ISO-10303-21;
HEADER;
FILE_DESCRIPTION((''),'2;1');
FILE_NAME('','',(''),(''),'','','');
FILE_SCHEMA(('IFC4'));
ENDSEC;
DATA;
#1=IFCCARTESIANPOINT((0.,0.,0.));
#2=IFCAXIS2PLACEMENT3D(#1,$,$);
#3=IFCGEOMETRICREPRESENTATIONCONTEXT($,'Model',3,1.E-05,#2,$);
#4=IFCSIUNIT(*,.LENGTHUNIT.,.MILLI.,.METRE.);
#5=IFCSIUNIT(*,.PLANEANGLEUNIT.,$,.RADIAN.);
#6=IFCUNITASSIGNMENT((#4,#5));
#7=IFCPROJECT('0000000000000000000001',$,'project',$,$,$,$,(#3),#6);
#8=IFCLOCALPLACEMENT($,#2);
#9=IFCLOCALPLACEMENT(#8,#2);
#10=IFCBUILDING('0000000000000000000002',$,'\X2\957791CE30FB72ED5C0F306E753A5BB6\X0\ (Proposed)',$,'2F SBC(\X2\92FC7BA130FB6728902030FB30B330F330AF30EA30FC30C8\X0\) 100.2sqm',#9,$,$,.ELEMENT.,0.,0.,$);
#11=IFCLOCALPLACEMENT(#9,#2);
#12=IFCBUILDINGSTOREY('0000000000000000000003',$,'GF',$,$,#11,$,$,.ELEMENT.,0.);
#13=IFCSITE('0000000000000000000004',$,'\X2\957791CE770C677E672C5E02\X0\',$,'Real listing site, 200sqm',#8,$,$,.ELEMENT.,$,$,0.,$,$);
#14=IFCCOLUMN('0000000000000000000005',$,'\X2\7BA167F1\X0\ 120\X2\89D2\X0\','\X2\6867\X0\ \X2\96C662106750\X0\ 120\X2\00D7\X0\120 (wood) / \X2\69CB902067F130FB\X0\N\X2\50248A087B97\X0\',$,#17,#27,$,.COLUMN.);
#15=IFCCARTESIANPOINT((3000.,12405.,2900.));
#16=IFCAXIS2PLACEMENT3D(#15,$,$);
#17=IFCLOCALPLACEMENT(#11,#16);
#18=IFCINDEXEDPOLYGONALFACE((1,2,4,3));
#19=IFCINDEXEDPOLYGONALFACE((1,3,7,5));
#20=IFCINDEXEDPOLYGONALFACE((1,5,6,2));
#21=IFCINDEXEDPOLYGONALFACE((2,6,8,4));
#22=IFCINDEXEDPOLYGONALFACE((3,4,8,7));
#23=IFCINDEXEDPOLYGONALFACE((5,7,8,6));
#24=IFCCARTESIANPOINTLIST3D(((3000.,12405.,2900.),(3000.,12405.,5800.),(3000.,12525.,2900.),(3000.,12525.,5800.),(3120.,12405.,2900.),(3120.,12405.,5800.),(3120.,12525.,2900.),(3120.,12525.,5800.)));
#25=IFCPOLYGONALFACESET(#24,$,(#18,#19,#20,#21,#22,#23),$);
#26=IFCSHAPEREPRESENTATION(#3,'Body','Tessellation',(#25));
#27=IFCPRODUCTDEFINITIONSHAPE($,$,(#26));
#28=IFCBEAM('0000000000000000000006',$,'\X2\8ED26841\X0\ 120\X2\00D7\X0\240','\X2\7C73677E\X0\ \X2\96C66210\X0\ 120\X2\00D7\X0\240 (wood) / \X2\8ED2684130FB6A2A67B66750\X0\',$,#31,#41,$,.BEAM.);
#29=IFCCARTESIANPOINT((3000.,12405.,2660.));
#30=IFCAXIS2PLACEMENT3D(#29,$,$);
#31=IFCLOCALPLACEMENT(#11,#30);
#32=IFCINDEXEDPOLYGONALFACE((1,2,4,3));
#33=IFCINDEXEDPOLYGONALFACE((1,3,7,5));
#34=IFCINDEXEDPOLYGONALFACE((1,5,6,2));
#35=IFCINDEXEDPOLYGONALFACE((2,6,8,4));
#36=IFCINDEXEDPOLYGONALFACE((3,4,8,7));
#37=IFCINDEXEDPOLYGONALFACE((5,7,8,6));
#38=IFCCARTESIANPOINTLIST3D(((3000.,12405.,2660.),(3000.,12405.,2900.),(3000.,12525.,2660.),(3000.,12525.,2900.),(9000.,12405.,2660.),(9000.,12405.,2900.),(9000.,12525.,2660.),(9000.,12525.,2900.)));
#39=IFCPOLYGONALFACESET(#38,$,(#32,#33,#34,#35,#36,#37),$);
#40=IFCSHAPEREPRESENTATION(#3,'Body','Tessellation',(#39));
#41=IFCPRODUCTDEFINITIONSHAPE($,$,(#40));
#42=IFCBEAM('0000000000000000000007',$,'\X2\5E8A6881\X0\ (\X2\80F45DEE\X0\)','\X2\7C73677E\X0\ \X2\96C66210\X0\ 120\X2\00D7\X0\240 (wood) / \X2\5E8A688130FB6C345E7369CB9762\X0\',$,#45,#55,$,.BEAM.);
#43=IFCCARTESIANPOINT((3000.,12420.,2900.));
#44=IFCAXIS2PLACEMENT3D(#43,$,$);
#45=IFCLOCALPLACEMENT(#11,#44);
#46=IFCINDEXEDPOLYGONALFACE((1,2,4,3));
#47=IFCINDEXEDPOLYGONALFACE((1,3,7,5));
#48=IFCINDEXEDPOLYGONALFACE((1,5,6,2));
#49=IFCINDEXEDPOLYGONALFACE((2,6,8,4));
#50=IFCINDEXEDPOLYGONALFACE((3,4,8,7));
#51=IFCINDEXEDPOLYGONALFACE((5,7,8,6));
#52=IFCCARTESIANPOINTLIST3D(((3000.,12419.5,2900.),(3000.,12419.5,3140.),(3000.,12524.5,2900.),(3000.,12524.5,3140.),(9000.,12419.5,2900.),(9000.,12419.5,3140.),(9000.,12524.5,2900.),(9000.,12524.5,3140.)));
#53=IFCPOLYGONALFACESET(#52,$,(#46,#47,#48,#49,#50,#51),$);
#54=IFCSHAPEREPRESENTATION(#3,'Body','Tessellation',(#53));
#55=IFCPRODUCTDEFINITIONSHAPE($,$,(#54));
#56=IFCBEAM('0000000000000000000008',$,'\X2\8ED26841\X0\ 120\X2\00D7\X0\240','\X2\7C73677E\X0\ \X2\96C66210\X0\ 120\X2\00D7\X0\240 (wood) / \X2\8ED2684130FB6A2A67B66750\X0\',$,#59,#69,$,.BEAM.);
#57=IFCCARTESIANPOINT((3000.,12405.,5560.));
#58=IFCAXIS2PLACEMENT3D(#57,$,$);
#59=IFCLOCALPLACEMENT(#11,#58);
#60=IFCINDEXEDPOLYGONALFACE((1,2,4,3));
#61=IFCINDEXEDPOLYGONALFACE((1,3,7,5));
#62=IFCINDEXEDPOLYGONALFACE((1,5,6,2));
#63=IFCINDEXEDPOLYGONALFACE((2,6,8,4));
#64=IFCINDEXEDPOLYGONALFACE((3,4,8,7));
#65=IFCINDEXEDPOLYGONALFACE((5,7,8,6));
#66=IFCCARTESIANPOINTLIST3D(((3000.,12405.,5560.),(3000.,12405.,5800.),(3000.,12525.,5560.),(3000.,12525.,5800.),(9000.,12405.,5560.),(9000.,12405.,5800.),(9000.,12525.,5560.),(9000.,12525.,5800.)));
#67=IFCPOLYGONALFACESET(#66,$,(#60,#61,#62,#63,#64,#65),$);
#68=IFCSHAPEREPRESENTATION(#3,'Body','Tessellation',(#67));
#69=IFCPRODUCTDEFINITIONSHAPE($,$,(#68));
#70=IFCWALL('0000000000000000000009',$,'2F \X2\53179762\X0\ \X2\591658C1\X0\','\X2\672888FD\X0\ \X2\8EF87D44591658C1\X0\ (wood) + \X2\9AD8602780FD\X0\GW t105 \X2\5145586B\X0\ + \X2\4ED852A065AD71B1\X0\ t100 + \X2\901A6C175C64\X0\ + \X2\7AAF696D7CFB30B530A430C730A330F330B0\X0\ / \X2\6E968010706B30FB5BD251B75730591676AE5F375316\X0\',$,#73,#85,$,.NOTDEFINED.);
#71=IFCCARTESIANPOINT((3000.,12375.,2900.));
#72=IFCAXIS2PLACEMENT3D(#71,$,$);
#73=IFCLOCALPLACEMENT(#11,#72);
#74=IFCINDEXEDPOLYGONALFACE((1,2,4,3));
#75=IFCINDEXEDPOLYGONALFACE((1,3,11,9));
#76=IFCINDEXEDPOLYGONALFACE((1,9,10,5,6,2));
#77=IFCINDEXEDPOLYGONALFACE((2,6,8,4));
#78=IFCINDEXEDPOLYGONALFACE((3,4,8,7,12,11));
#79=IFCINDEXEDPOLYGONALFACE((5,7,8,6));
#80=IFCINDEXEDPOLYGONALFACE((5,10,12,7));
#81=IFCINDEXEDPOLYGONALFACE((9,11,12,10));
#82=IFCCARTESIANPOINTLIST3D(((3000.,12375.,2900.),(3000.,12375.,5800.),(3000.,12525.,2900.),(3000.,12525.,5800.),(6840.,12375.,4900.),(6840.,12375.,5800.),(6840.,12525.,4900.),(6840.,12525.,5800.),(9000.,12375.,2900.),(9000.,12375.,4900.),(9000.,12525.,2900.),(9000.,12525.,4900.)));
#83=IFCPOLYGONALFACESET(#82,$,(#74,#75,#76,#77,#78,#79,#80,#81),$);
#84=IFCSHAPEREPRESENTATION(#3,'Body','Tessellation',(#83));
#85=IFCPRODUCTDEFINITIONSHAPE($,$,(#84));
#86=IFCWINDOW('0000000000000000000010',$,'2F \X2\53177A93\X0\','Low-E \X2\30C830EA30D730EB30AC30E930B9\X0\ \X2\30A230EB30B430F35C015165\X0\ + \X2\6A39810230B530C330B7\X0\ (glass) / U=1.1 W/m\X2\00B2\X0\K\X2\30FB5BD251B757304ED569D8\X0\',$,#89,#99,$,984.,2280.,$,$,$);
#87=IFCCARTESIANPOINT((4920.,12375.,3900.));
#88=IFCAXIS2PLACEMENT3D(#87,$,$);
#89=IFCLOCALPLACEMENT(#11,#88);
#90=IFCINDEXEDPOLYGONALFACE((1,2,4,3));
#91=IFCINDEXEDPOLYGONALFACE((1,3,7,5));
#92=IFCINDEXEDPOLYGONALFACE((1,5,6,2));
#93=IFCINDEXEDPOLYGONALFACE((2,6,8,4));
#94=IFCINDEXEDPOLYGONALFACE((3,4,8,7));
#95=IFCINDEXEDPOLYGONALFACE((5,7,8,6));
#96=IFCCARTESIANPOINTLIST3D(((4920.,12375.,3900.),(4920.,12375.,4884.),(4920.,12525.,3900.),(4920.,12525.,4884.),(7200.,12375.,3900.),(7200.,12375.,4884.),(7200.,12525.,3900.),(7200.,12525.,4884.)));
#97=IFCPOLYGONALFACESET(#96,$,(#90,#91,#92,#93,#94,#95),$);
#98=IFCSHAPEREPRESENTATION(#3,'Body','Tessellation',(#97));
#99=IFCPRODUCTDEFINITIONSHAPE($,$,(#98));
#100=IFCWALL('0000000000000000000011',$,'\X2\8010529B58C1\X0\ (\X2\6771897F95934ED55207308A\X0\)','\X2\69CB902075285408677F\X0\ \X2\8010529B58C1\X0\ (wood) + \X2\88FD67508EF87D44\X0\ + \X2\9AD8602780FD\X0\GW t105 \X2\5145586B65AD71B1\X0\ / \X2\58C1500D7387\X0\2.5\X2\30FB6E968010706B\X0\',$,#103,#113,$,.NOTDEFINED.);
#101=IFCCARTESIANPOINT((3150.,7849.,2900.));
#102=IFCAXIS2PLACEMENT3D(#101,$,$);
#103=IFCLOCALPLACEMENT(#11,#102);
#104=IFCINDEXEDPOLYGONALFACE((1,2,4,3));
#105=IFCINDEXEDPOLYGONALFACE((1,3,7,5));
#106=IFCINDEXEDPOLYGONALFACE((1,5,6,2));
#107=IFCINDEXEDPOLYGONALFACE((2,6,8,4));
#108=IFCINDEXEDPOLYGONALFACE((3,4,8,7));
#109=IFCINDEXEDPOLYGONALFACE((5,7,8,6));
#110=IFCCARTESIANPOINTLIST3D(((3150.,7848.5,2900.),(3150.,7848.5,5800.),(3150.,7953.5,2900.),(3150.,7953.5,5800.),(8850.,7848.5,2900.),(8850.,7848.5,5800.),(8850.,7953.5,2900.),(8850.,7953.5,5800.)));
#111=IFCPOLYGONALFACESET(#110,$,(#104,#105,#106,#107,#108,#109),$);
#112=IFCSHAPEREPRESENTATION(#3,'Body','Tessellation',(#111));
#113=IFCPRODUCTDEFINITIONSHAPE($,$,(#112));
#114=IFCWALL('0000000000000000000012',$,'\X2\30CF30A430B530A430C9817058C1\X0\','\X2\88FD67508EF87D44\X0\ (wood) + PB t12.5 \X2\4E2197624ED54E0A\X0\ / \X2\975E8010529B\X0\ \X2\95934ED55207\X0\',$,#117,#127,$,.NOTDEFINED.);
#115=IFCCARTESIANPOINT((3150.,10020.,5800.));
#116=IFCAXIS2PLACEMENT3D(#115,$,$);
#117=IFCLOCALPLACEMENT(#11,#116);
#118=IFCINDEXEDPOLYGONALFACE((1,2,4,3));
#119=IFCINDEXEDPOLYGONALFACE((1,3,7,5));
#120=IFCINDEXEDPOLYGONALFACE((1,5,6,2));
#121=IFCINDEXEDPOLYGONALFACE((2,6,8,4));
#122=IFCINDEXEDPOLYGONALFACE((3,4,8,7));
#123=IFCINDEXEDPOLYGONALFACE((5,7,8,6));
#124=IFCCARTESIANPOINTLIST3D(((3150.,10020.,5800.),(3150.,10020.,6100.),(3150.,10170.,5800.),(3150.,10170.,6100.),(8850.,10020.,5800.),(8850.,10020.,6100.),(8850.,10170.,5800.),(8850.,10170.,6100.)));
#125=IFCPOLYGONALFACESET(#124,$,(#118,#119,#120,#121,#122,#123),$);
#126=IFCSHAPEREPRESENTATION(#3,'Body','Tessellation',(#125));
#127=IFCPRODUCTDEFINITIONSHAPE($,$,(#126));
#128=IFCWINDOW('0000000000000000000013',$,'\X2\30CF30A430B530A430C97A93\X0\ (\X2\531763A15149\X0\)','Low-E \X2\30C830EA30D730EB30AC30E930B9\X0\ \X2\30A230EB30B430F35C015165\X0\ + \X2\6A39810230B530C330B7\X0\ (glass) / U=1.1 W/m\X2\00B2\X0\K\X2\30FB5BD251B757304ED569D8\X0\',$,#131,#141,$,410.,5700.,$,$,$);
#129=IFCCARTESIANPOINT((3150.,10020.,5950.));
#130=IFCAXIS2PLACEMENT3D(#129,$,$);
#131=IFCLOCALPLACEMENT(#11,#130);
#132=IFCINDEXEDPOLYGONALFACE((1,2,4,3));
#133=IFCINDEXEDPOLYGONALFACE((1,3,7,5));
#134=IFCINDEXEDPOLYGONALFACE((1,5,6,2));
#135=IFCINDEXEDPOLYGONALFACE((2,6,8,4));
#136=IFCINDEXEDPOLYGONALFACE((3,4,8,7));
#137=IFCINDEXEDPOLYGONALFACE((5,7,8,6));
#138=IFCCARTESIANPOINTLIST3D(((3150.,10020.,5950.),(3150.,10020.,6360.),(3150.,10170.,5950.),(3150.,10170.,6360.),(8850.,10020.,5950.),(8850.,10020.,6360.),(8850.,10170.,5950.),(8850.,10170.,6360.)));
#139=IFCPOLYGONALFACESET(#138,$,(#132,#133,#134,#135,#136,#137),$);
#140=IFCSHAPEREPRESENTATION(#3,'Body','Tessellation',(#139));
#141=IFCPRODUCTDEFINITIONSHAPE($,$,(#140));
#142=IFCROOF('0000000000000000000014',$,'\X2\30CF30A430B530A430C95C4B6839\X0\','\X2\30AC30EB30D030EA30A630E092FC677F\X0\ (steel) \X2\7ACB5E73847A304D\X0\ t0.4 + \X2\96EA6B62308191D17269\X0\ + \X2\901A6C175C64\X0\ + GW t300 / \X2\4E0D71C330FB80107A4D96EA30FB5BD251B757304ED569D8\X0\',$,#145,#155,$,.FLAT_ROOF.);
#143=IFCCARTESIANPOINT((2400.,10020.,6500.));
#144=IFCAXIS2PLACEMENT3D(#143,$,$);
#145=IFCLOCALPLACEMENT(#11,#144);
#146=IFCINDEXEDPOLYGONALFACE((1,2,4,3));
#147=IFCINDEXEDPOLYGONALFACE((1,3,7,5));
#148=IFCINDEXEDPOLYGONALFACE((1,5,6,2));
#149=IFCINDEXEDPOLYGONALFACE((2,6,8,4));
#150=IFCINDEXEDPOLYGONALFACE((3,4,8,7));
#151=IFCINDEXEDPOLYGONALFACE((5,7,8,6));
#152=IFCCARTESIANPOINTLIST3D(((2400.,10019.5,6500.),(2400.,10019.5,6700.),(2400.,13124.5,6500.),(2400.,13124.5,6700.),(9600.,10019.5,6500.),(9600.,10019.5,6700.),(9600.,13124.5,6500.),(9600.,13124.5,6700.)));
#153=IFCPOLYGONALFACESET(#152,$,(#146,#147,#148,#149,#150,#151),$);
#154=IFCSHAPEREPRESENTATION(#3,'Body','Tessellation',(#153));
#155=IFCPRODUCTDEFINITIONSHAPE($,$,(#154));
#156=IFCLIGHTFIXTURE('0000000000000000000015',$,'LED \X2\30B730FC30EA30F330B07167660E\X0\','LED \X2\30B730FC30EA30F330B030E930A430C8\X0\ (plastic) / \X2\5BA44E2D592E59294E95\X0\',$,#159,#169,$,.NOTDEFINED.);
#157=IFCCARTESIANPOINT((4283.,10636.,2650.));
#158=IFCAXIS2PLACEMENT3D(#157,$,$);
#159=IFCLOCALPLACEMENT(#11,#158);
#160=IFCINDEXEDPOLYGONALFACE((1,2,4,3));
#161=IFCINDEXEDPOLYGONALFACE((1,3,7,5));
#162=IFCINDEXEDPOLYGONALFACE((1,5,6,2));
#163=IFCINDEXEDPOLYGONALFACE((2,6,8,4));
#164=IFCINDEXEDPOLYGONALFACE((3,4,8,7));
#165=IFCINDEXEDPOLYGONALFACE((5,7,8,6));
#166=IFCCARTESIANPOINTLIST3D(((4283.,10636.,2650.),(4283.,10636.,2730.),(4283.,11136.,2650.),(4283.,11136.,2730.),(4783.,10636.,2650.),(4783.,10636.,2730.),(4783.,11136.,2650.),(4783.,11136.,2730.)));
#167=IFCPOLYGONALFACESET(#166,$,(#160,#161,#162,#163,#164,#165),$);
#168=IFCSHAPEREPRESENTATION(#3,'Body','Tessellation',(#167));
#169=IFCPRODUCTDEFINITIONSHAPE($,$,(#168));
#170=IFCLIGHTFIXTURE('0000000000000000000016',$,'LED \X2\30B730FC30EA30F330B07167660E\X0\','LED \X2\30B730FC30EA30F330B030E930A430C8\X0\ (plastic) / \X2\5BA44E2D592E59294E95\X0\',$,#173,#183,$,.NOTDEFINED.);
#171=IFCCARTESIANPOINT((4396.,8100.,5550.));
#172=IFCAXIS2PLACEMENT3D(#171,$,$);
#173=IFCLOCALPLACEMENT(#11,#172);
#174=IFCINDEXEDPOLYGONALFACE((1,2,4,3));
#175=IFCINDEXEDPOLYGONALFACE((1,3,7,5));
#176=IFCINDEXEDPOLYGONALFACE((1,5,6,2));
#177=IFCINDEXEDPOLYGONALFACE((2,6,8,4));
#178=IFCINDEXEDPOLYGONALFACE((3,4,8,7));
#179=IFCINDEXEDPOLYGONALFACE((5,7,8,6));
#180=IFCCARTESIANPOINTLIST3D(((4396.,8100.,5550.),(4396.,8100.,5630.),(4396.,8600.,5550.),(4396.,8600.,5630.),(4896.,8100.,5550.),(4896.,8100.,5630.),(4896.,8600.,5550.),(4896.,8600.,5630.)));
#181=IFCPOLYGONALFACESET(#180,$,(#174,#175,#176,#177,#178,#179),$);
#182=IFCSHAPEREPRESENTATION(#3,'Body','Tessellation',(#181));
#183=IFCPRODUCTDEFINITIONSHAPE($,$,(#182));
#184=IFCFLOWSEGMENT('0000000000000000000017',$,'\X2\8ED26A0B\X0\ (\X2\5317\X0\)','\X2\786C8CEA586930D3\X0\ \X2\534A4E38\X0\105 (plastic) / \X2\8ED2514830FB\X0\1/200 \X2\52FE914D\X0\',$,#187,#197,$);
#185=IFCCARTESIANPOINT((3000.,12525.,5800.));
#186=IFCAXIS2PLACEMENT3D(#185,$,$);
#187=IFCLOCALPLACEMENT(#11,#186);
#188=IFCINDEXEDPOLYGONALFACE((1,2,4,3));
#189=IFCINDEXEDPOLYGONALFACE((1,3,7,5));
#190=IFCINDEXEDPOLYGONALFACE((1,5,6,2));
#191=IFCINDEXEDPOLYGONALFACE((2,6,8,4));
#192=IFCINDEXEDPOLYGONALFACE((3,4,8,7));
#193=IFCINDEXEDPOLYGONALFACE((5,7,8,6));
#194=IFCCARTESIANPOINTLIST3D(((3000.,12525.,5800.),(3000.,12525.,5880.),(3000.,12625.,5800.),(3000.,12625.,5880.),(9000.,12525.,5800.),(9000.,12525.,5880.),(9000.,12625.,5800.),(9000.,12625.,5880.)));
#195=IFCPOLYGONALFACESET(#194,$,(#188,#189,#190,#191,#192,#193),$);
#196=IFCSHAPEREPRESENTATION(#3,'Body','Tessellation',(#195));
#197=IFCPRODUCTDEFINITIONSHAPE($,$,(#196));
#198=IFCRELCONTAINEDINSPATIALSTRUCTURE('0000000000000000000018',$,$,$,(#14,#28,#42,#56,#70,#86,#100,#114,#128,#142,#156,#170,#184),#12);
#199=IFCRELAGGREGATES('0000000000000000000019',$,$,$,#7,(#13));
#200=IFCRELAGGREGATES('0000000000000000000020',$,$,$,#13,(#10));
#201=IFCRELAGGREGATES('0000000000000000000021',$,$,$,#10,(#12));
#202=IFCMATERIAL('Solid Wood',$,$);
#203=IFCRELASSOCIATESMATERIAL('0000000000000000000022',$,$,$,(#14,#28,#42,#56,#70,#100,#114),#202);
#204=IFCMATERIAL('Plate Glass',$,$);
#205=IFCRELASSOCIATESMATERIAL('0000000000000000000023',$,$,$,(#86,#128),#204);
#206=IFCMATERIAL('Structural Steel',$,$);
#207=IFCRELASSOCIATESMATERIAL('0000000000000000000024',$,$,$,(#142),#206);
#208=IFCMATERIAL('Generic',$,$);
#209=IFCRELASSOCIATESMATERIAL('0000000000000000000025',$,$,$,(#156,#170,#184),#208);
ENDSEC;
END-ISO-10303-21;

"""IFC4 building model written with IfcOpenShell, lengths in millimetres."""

from ifc_helpers import new_model, si_unit, frame, frame_2d, origin, place, context, project, spatial, rectangle, extrude, material, element, fill, save


model = new_model("IFC4")

# Units and contexts
model_context = context("Model", 3, precision=1e-05, world=origin())
ifc_project = project(units=[si_unit("LENGTHUNIT", "METRE", prefix="MILLI"), si_unit("PLANEANGLEUNIT", "RADIAN")], contexts=[model_context])

# Site, building, storey
site_placement = place(None, origin())
site = spatial("IfcSite", under=ifc_project, at=site_placement, Name="長野県松本市", ObjectType="Real listing site, 200sqm", CompositionType="ELEMENT", RefElevation=0.0)
building_placement = place(site_placement, origin())
building = spatial("IfcBuilding", under=site, at=building_placement, Name="長野・狭小の町家 (Proposed)", ObjectType="2F SBC(鋼管・木造・コンクリート) 100.2sqm", CompositionType="ELEMENT", ElevationOfRefHeight=0.0, ElevationOfTerrain=0.0)
storey_placement = place(building_placement, origin())
storey = spatial("IfcBuildingStorey", under=building, at=storey_placement, Name="GF", CompositionType="ELEMENT", Elevation=0.0)

# Column
ifc_material_1 = material(Name="Solid Wood")
column_1_placement = place(storey_placement, frame((3000.0, 12405.0, 2900.0)))
element("IfcColumn", 1, at=column_1_placement, inside=storey, material=ifc_material_1, Name="管柱 120角", Description="桧 集成材 120×120 (wood) / 構造柱・N値計算", PredefinedType="COLUMN", context=model_context, shape_type="SweptSolid", body=[
    extrude(rectangle(XDim=120.0, YDim=120.0, at=frame_2d((60.0, 60.0))), frame((3000.0, 12405.0, 2900.0)), (0.0, 0.0, 1.0), 2900.0),
])

# Beams
beam_1_placement = place(storey_placement, frame((3000.0, 12405.0, 2660.0)))
element("IfcBeam", 2, at=beam_1_placement, inside=storey, material=ifc_material_1, Name="軒桁 120×240", Description="米松 集成 120×240 (wood) / 軒桁・横架材", PredefinedType="BEAM", context=model_context, shape_type="SweptSolid", body=[
    extrude(rectangle(XDim=6000.0, YDim=120.0, at=frame_2d((3000.0, 60.0))), frame((3000.0, 12405.0, 2660.0)), (0.0, 0.0, 1.0), 240.0),
])
beam_2_placement = place(storey_placement, frame((3000.0, 12420.0, 2900.0)))
element("IfcBeam", 3, at=beam_2_placement, inside=storey, material=ifc_material_1, Name="床梁 (胴差)", Description="米松 集成 120×240 (wood) / 床梁・水平構面", PredefinedType="BEAM", context=model_context, shape_type="SweptSolid", body=[
    extrude(rectangle(XDim=6000.0, YDim=105.0, at=frame_2d((3000.0, 52.0))), frame((3000.0, 12420.0, 2900.0)), (0.0, 0.0, 1.0), 240.0),
])
beam_3_placement = place(storey_placement, frame((3000.0, 12405.0, 5560.0)))
element("IfcBeam", 4, at=beam_3_placement, inside=storey, material=ifc_material_1, Name="軒桁 120×240", Description="米松 集成 120×240 (wood) / 軒桁・横架材", PredefinedType="BEAM", context=model_context, shape_type="SweptSolid", body=[
    extrude(rectangle(XDim=6000.0, YDim=120.0, at=frame_2d((3000.0, 60.0))), frame((3000.0, 12405.0, 5560.0)), (0.0, 0.0, 1.0), 240.0),
])

# Wall, opening, window
wall_1_placement = place(storey_placement, frame((3000.0, 12375.0, 2900.0)))
wall_1 = element("IfcWall", 5, at=wall_1_placement, inside=storey, material=ifc_material_1, Name="2F 北面 外壁", Description="木製 軸組外壁 (wood) + 高性能GW t105 充填 + 付加断熱 t100 + 通気層 + 窯業系サイディング / 準耐火・寒冷地外皮強化", PredefinedType="NOTDEFINED", context=model_context, shape_type="SweptSolid", body=[
    extrude(rectangle(XDim=6000.0, YDim=150.0, at=frame_2d((3000.0, 75.0))), frame((3000.0, 12375.0, 2900.0)), (0.0, 0.0, 1.0), 2900.0),
])
opening_1_placement = place(storey_placement, frame((4920.0, 12375.0, 3900.0)))
opening_1 = element("IfcOpeningElement", 6, at=opening_1_placement, cuts=wall_1, PredefinedType="NOTDEFINED", context=model_context, shape_type="SweptSolid", body=[
    extrude(rectangle(XDim=2280.0, YDim=150.0, at=frame_2d((1140.0, 75.0))), frame((4920.0, 12375.0, 3900.0)), (0.0, 0.0, 1.0), 984.0),
])
ifc_material_2 = material(Name="Plate Glass")
window_1_placement = place(storey_placement, frame((4920.0, 12375.0, 3900.0)))
window_1 = element("IfcWindow", 7, at=window_1_placement, inside=storey, material=ifc_material_2, Name="2F 北窓", Description="Low-E トリプルガラス アルゴン封入 + 樹脂サッシ (glass) / U=1.1 W/m²K・寒冷地仕様", OverallHeight=984.0, OverallWidth=2280.0, context=model_context, shape_type="SweptSolid", body=[
    extrude(rectangle(XDim=2280.0, YDim=150.0, at=frame_2d((1140.0, 75.0))), frame((4920.0, 12375.0, 3900.0)), (0.0, 0.0, 1.0), 984.0),
])
fill(opening_1, window_1)

# Wall
wall_2_placement = place(storey_placement, frame((3150.0, 7849.0, 2900.0)))
element("IfcWall", 8, at=wall_2_placement, inside=storey, material=ifc_material_1, Name="耐力壁 (東西間仕切り)", Description="構造用合板 耐力壁 (wood) + 製材軸組 + 高性能GW t105 充填断熱 / 壁倍率2.5・準耐火", PredefinedType="NOTDEFINED", context=model_context, shape_type="SweptSolid", body=[
    extrude(rectangle(XDim=5700.0, YDim=105.0, at=frame_2d((2850.0, 52.0))), frame((3150.0, 7849.0, 2900.0)), (0.0, 0.0, 1.0), 2900.0),
])

# Wall, opening, window
wall_3_placement = place(storey_placement, frame((3150.0, 10020.0, 5800.0)))
wall_3 = element("IfcWall", 9, at=wall_3_placement, inside=storey, material=ifc_material_1, Name="ハイサイド腰壁", Description="製材軸組 (wood) + PB t12.5 両面仕上 / 非耐力 間仕切", PredefinedType="NOTDEFINED", context=model_context, shape_type="SweptSolid", body=[
    extrude(rectangle(XDim=5700.0, YDim=150.0, at=frame_2d((2850.0, 75.0))), frame((3150.0, 10020.0, 5800.0)), (0.0, 0.0, 1.0), 700.0),
])
opening_2_placement = place(storey_placement, frame((3150.0, 10020.0, 5950.0)))
opening_2 = element("IfcOpeningElement", 10, at=opening_2_placement, cuts=wall_3, PredefinedType="NOTDEFINED", context=model_context, shape_type="SweptSolid", body=[
    extrude(rectangle(XDim=5700.0, YDim=150.0, at=frame_2d((2850.0, 75.0))), frame((3150.0, 10020.0, 5950.0)), (0.0, 0.0, 1.0), 410.0),
])
window_2_placement = place(storey_placement, frame((3150.0, 10020.0, 5950.0)))
window_2 = element("IfcWindow", 11, at=window_2_placement, inside=storey, material=ifc_material_2, Name="ハイサイド窓 (北採光)", Description="Low-E トリプルガラス アルゴン封入 + 樹脂サッシ (glass) / U=1.1 W/m²K・寒冷地仕様", OverallHeight=410.0, OverallWidth=5700.0, context=model_context, shape_type="SweptSolid", body=[
    extrude(rectangle(XDim=5700.0, YDim=150.0, at=frame_2d((2850.0, 75.0))), frame((3150.0, 10020.0, 5950.0)), (0.0, 0.0, 1.0), 410.0),
])
fill(opening_2, window_2)

# Roof
ifc_material_3 = material(Name="Structural Steel")
roof_placement = place(storey_placement, frame((2400.0, 10020.0, 6500.0)))
element("IfcRoof", 12, at=roof_placement, inside=storey, material=ifc_material_3, Name="ハイサイド屋根", Description="ガルバリウム鋼板 (steel) 立平葺き t0.4 + 雪止め金物 + 通気層 + GW t300 / 不燃・耐積雪・寒冷地仕様", PredefinedType="FLAT_ROOF", context=model_context, shape_type="SweptSolid", body=[
    extrude(rectangle(XDim=7200.0, YDim=3105.0, at=frame_2d((3600.0, 1552.0))), frame((2400.0, 10020.0, 6500.0)), (0.0, 0.0, 1.0), 200.0),
])

# Light fixtures
ifc_material_4 = material(Name="Generic")
light_fixture_1_placement = place(storey_placement, frame((4283.0, 10636.0, 2650.0)))
element("IfcLightFixture", 13, at=light_fixture_1_placement, inside=storey, material=ifc_material_4, Name="LED シーリング照明", Description="LED シーリングライト (plastic) / 室中央天井", PredefinedType="NOTDEFINED", context=model_context, shape_type="SweptSolid", body=[
    extrude(rectangle(XDim=500.0, YDim=500.0, at=frame_2d((250.0, 250.0))), frame((4283.0, 10636.0, 2650.0)), (0.0, 0.0, 1.0), 80.0),
])
light_fixture_2_placement = place(storey_placement, frame((4396.0, 8100.0, 5550.0)))
element("IfcLightFixture", 14, at=light_fixture_2_placement, inside=storey, material=ifc_material_4, Name="LED シーリング照明", Description="LED シーリングライト (plastic) / 室中央天井", PredefinedType="NOTDEFINED", context=model_context, shape_type="SweptSolid", body=[
    extrude(rectangle(XDim=500.0, YDim=500.0, at=frame_2d((250.0, 250.0))), frame((4396.0, 8100.0, 5550.0)), (0.0, 0.0, 1.0), 80.0),
])

# Flow segment
flow_segment_placement = place(storey_placement, frame((3000.0, 12525.0, 5800.0)))
element("IfcFlowSegment", 15, at=flow_segment_placement, inside=storey, material=ifc_material_4, Name="軒樋 (北)", Description="硬質塩ビ 半丸105 (plastic) / 軒先・1/200 勾配", context=model_context, shape_type="SweptSolid", body=[
    extrude(rectangle(XDim=6000.0, YDim=100.0, at=frame_2d((3000.0, 50.0))), frame((3000.0, 12525.0, 5800.0)), (0.0, 0.0, 1.0), 80.0),
])

save(model, "model.ifc")
